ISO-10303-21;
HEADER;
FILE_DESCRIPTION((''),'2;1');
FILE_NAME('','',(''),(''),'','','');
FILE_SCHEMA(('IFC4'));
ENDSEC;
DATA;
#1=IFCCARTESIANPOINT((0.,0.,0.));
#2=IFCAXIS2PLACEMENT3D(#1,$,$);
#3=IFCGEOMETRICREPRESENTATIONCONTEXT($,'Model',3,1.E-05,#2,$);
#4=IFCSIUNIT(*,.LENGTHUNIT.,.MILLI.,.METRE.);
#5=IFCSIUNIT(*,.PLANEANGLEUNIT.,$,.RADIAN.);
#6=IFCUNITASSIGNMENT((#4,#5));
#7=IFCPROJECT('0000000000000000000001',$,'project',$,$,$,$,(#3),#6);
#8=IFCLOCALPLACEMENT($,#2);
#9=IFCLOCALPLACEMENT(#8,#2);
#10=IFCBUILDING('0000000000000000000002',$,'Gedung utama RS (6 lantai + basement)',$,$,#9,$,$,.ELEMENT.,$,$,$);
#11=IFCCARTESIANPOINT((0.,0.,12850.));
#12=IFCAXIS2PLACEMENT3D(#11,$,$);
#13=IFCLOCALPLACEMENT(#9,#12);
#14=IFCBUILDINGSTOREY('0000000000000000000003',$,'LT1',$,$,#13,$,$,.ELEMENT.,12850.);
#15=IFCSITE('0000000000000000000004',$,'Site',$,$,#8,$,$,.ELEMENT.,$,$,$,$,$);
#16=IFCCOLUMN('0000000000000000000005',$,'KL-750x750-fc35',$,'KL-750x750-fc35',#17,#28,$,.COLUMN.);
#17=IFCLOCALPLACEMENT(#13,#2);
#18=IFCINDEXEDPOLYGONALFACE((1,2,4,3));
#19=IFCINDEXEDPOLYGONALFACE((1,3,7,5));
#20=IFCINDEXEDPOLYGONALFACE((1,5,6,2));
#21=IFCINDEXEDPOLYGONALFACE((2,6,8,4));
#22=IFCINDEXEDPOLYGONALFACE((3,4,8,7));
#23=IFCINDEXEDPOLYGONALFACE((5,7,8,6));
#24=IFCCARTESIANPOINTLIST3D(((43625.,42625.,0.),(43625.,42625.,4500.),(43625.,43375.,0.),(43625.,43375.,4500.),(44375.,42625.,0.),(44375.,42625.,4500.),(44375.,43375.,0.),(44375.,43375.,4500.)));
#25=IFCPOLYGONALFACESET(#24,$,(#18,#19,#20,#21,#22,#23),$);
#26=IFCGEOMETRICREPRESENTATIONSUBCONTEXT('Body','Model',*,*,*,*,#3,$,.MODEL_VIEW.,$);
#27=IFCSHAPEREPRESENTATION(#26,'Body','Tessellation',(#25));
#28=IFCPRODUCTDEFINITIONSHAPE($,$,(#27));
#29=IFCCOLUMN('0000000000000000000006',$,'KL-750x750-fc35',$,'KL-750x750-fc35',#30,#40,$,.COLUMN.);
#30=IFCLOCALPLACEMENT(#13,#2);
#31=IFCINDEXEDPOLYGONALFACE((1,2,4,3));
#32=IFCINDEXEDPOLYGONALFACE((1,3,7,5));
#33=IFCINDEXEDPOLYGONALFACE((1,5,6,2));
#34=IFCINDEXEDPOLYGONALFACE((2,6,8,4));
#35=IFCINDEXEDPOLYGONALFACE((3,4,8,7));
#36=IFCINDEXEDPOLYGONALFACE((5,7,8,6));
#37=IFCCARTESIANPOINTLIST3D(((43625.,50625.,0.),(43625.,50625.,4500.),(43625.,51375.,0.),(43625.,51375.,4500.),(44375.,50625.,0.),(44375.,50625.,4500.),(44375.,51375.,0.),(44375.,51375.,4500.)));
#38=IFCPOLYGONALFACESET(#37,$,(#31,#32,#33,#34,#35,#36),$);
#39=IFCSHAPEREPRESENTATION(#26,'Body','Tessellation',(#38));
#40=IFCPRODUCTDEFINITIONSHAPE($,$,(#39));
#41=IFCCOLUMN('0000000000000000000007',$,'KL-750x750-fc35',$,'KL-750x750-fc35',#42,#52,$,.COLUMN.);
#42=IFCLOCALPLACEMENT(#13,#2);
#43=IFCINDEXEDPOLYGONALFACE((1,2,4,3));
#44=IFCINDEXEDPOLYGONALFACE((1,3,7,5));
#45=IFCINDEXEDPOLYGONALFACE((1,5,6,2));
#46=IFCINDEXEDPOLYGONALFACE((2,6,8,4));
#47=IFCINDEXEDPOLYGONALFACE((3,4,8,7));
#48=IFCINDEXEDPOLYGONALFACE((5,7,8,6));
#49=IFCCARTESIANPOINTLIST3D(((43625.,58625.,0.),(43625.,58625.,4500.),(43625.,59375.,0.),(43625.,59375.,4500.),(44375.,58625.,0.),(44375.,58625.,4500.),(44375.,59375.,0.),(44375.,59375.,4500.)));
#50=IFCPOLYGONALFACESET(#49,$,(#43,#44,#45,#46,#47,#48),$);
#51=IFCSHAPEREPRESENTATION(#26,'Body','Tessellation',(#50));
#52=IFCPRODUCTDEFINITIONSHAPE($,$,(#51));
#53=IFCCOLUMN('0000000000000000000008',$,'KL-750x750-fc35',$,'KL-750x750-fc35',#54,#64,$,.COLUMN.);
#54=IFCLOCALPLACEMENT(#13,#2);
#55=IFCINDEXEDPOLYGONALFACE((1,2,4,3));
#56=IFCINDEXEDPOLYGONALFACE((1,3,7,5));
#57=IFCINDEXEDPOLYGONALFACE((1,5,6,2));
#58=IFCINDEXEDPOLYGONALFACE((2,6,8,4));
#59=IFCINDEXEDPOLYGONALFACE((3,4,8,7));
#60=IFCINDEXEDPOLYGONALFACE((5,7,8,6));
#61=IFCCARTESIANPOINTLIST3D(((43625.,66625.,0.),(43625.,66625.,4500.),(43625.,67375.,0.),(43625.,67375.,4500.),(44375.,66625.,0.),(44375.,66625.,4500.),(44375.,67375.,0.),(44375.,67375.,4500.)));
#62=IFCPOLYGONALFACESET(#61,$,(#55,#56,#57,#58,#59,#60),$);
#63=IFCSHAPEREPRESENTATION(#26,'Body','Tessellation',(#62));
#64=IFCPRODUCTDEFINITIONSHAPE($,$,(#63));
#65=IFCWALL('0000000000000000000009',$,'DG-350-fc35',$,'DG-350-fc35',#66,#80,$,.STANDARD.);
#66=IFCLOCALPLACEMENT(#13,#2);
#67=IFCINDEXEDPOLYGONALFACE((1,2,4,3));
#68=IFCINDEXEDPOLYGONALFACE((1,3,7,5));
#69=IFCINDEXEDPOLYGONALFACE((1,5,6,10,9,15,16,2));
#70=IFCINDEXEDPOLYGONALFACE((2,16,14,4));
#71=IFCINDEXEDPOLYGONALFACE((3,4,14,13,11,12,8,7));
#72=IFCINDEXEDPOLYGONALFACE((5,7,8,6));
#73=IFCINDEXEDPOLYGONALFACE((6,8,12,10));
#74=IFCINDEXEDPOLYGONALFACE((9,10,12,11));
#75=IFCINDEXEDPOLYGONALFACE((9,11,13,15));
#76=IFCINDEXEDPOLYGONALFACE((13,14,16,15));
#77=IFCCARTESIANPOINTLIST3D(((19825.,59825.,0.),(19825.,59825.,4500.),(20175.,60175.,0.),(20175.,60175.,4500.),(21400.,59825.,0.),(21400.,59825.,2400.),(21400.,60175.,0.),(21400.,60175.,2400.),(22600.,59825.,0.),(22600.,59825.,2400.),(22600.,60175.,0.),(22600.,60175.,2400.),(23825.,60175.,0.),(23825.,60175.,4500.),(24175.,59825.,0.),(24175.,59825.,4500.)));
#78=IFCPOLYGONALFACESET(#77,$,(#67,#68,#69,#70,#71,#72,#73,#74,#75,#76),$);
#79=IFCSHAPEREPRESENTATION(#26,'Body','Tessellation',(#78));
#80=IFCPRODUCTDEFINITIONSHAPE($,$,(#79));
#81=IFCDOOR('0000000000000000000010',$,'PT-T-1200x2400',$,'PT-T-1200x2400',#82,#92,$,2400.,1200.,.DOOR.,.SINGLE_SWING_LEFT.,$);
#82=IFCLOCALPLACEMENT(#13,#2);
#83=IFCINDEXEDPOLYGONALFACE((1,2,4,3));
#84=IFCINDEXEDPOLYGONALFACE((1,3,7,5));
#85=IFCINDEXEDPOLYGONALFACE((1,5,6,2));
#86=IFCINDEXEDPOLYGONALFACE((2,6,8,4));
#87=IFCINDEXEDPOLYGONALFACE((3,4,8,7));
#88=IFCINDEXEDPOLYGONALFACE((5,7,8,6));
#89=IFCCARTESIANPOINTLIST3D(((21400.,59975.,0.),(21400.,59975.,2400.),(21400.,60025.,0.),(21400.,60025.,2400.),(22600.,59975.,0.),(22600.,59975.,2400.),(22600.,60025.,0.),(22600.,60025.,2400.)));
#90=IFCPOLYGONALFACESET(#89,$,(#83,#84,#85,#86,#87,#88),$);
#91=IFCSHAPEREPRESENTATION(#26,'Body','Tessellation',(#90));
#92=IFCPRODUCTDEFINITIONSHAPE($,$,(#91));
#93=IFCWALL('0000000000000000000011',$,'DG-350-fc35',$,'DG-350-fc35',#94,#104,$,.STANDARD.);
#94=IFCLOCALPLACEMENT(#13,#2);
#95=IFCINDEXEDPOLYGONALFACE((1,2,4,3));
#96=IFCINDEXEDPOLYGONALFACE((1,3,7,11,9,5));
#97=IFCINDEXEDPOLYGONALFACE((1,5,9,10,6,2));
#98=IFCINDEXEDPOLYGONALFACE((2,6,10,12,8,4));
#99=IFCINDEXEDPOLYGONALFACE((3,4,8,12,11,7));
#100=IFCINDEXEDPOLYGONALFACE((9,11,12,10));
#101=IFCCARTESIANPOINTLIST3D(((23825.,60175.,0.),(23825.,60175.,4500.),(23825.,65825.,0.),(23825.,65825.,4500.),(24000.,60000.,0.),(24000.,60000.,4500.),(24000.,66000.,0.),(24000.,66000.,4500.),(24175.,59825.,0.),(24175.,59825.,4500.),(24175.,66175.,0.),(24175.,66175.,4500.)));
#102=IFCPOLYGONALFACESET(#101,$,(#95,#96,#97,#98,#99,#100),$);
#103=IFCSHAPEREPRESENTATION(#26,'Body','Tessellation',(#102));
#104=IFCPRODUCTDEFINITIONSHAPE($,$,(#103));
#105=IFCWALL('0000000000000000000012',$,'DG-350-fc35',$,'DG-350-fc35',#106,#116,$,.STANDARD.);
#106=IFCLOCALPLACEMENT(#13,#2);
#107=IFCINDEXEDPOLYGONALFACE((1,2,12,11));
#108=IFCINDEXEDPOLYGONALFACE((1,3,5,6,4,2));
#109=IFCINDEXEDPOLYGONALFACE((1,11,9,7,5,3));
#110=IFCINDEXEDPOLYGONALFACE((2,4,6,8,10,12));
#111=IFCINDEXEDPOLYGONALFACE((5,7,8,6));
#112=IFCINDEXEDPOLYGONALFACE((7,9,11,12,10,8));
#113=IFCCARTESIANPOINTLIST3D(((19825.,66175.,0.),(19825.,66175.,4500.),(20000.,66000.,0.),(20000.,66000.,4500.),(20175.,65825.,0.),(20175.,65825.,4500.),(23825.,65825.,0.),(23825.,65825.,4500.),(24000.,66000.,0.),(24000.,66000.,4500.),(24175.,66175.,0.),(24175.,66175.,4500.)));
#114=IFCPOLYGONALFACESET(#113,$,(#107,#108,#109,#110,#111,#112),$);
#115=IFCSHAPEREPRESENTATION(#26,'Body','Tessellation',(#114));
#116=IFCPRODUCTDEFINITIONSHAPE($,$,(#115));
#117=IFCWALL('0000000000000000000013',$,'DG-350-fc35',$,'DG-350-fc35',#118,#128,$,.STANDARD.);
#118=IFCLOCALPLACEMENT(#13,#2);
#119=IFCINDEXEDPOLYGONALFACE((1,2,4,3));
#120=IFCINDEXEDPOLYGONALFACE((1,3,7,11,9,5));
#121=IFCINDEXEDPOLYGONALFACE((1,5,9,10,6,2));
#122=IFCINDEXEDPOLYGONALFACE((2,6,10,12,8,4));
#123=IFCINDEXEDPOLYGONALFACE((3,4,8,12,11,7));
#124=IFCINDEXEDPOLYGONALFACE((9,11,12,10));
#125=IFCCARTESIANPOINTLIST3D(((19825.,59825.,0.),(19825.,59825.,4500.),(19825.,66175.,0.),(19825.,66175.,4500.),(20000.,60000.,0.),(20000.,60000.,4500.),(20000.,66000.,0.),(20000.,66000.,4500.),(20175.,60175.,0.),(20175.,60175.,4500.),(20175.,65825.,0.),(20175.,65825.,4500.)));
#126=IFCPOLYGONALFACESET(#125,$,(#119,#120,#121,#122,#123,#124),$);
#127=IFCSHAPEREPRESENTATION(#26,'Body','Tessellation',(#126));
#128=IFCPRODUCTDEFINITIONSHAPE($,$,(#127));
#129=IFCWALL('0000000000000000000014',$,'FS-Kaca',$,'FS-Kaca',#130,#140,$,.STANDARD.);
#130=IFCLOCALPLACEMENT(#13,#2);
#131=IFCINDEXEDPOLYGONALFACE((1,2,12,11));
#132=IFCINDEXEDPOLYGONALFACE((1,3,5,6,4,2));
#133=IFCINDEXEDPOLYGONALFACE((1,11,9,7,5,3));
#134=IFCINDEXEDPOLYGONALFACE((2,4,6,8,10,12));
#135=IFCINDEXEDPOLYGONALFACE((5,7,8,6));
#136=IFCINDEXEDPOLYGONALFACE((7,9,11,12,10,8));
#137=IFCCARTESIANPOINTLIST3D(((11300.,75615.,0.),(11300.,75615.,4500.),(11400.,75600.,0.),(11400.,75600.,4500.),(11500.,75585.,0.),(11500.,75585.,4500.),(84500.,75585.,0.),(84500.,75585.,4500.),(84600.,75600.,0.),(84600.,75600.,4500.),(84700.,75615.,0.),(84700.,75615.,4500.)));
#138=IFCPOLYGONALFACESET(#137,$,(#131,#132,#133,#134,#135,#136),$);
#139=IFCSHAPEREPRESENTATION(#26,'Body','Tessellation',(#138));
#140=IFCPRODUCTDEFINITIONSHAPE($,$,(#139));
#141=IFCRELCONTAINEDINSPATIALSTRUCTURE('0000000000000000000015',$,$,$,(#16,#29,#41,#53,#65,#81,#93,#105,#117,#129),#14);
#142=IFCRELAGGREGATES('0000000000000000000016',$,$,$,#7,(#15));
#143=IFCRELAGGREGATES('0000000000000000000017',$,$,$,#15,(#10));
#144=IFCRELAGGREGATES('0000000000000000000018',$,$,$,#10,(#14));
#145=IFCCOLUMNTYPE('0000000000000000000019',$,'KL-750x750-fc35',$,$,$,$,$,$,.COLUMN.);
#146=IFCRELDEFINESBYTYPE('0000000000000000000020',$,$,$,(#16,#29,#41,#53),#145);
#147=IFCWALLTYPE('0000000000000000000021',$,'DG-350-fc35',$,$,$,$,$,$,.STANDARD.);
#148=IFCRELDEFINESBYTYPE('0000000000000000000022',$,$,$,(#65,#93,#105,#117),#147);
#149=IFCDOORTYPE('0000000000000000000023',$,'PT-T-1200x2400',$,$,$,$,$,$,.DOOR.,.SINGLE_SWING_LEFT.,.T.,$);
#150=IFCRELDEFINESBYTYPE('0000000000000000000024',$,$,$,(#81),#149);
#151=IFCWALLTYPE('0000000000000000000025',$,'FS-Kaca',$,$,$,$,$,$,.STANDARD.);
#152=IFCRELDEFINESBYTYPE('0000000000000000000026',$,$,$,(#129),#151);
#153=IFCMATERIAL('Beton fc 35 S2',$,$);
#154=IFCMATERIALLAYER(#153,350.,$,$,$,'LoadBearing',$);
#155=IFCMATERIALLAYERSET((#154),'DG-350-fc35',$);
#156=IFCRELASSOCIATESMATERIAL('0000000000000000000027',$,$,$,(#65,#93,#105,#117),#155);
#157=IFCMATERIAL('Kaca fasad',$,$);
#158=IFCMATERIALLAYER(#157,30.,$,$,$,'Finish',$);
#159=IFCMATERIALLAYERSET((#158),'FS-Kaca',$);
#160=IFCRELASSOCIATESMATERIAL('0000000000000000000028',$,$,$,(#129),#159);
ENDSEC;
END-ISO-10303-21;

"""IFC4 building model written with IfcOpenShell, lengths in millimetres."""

from ifc_helpers import new_model, si_unit, frame, frame_2d, origin, origin_2d, place, context, subcontext, project, spatial, polyline, rectangle, outline, extrude, material, layer, layer_set, layer_usage, material_profile, profile_set, profile_usage, type_object, element, fill, save


model = new_model("IFC4")

# Units and contexts
model_context = context("Model", 3, precision=1e-05, world=origin())
body_context = subcontext(model_context, "Body", "Model", "MODEL_VIEW")
ifc_project = project(units=[si_unit("LENGTHUNIT", "METRE", prefix="MILLI"), si_unit("PLANEANGLEUNIT", "RADIAN")], contexts=[model_context])

# Site, building, storey
site_placement = place(None, origin())
site = spatial("IfcSite", under=ifc_project, at=site_placement, Name="Site", CompositionType="ELEMENT")
building_placement = place(site_placement, origin())
building = spatial("IfcBuilding", under=site, at=building_placement, Name="Gedung utama RS (6 lantai + basement)", CompositionType="ELEMENT")
storey_placement = place(building_placement, frame((0.0, 0.0, 12850.0)))
storey = spatial("IfcBuildingStorey", under=building, at=storey_placement, Name="LT1", CompositionType="ELEMENT", Elevation=12850.0)

# Columns
ifc_material_profile = material_profile(None, rectangle(XDim=750.0, YDim=750.0, at=origin_2d()), Name="KL-750x750-fc35")
ifc_profile_set = profile_set([ifc_material_profile], Name="KL-750x750-fc35")
ifc_profile_usage = profile_usage(ifc_profile_set, cardinal=5)
column_type = type_object("IfcColumnType", Name="KL-750x750-fc35", PredefinedType="COLUMN", material=ifc_profile_set)
for number, where, z_axis, x_axis, name in (
    (1, (44000.0, 43000.0, 0.0), (0.0, 0.0, 1.0), (1.0, 0.0, 0.0), "KL-750x750-fc35"),
    (2, (44000.0, 51000.0, 0.0), (0.0, 0.0, 1.0), (1.0, 0.0, 0.0), "KL-750x750-fc35"),
    (3, (44000.0, 59000.0, 0.0), (0.0, 0.0, 1.0), (1.0, 0.0, 0.0), "KL-750x750-fc35"),
    (4, (44000.0, 67000.0, 0.0), (0.0, 0.0, 1.0), (1.0, 0.0, 0.0), "KL-750x750-fc35"),
):
    element("IfcColumn", number, at=place(storey_placement, frame(where, z_axis=z_axis, x_axis=x_axis)), inside=storey, type_object=column_type, material=ifc_profile_usage, Name=name, ObjectType="KL-750x750-fc35", PredefinedType="COLUMN", context=body_context, shape_type="SweptSolid", body=[
        extrude(rectangle(XDim=750.0, YDim=750.0, at=origin_2d()), origin(), (0.0, 0.0, 1.0), 4500.0),
    ])

# Wall, opening, door
ifc_material_1 = material(Name="Beton fc 35 S2")
ifc_layer_1 = layer(ifc_material_1, 350.0, Category="LoadBearing")
ifc_layer_set_1 = layer_set([ifc_layer_1], Name="DG-350-fc35")
ifc_layer_usage_1 = layer_usage(ifc_layer_set_1, "AXIS2", "NEGATIVE", 175.0)
wall_type_1 = type_object("IfcWallType", Name="DG-350-fc35", PredefinedType="STANDARD")
wall_1_placement = place(storey_placement, frame((20000.0, 60000.0, 0.0), z_axis=(0.0, 0.0, 1.0), x_axis=(1.0, 0.0, 0.0)))
wall_1 = element("IfcWall", 5, at=wall_1_placement, inside=storey, type_object=wall_type_1, material=ifc_layer_usage_1, Name="DG-350-fc35", ObjectType="DG-350-fc35", PredefinedType="STANDARD", context=body_context, shape_type="SweptSolid", body=[
    extrude(outline(polyline([(-175.0, -175.0), (0.0, 0.0), (175.0, 175.0), (3825.0, 175.0), (4000.0, 0.0), (4175.0, -175.0), (-175.0, -175.0)])), origin(), (0.0, 0.0, 1.0), 4500.0),
])
opening_placement = place(wall_1_placement, frame((1400.0, 0.0, 0.0), z_axis=(0.0, 0.0, 1.0), x_axis=(1.0, 0.0, 0.0)))
opening = element("IfcOpeningElement", 6, at=opening_placement, cuts=wall_1, PredefinedType="OPENING", context=body_context, shape_type="SweptSolid", body=[
    extrude(rectangle(XDim=1200.0, YDim=370.0, at=frame_2d((600.0, 0.0))), origin(), (0.0, 0.0, 1.0), 2400.0),
])
door_type = type_object("IfcDoorType", Name="PT-T-1200x2400", OperationType="SINGLE_SWING_LEFT", ParameterTakesPrecedence=True, PredefinedType="DOOR")
door_placement = place(opening_placement, origin())
door = element("IfcDoor", 7, at=door_placement, inside=storey, type_object=door_type, Name="PT-T-1200x2400", ObjectType="PT-T-1200x2400", OperationType="SINGLE_SWING_LEFT", OverallHeight=2400.0, OverallWidth=1200.0, PredefinedType="DOOR", context=body_context, shape_type="SweptSolid", body=[
    extrude(rectangle(XDim=1200.0, YDim=50.0, at=frame_2d((600.0, 0.0))), origin(), (0.0, 0.0, 1.0), 2400.0),
])
fill(opening, door)

# Walls
wall_2_placement = place(storey_placement, frame((24000.0, 60000.0, 0.0), z_axis=(0.0, 0.0, 1.0), x_axis=(0.0, 1.0, 0.0)))
element("IfcWall", 8, at=wall_2_placement, inside=storey, type_object=wall_type_1, material=ifc_layer_usage_1, Name="DG-350-fc35", ObjectType="DG-350-fc35", PredefinedType="STANDARD", context=body_context, shape_type="SweptSolid", body=[
    extrude(outline(polyline([(-175.0, -175.0), (0.0, 0.0), (175.0, 175.0), (5825.0, 175.0), (6000.0, 0.0), (6175.0, -175.0), (-175.0, -175.0)])), origin(), (0.0, 0.0, 1.0), 4500.0),
])
wall_3_placement = place(storey_placement, frame((24000.0, 66000.0, 0.0), z_axis=(0.0, 0.0, 1.0), x_axis=(-1.0, 0.0, 0.0)))
element("IfcWall", 9, at=wall_3_placement, inside=storey, type_object=wall_type_1, material=ifc_layer_usage_1, Name="DG-350-fc35", ObjectType="DG-350-fc35", PredefinedType="STANDARD", context=body_context, shape_type="SweptSolid", body=[
    extrude(outline(polyline([(-175.0, -175.0), (0.0, 0.0), (175.0, 175.0), (3825.0, 175.0), (4000.0, 0.0), (4175.0, -175.0), (-175.0, -175.0)])), origin(), (0.0, 0.0, 1.0), 4500.0),
])
wall_4_placement = place(storey_placement, frame((20000.0, 66000.0, 0.0), z_axis=(0.0, 0.0, 1.0), x_axis=(0.0, -1.0, 0.0)))
element("IfcWall", 10, at=wall_4_placement, inside=storey, type_object=wall_type_1, material=ifc_layer_usage_1, Name="DG-350-fc35", ObjectType="DG-350-fc35", PredefinedType="STANDARD", context=body_context, shape_type="SweptSolid", body=[
    extrude(outline(polyline([(-175.0, -175.0), (0.0, 0.0), (175.0, 175.0), (5825.0, 175.0), (6000.0, 0.0), (6175.0, -175.0), (-175.0, -175.0)])), origin(), (0.0, 0.0, 1.0), 4500.0),
])
ifc_material_2 = material(Name="Kaca fasad")
ifc_layer_2 = layer(ifc_material_2, 30.0, Category="Finish")
ifc_layer_set_2 = layer_set([ifc_layer_2], Name="FS-Kaca")
ifc_layer_usage_2 = layer_usage(ifc_layer_set_2, "AXIS2", "NEGATIVE", 15.0)
wall_type_2 = type_object("IfcWallType", Name="FS-Kaca", PredefinedType="STANDARD")
wall_5_placement = place(storey_placement, frame((11400.0, 75600.0, 0.0), z_axis=(0.0, 0.0, 1.0), x_axis=(1.0, 0.0, 0.0)))
element("IfcWall", 11, at=wall_5_placement, inside=storey, type_object=wall_type_2, material=ifc_layer_usage_2, Name="FS-Kaca", ObjectType="FS-Kaca", PredefinedType="STANDARD", context=body_context, shape_type="SweptSolid", body=[
    extrude(outline(polyline([(100.0, -15.0), (0.0, 0.0), (-100.0, 15.0), (73300.0, 15.0), (73200.0, 0.0), (73100.0, -15.0), (100.0, -15.0)])), origin(), (0.0, 0.0, 1.0), 4500.0),
])

save(model, "model.ifc")
